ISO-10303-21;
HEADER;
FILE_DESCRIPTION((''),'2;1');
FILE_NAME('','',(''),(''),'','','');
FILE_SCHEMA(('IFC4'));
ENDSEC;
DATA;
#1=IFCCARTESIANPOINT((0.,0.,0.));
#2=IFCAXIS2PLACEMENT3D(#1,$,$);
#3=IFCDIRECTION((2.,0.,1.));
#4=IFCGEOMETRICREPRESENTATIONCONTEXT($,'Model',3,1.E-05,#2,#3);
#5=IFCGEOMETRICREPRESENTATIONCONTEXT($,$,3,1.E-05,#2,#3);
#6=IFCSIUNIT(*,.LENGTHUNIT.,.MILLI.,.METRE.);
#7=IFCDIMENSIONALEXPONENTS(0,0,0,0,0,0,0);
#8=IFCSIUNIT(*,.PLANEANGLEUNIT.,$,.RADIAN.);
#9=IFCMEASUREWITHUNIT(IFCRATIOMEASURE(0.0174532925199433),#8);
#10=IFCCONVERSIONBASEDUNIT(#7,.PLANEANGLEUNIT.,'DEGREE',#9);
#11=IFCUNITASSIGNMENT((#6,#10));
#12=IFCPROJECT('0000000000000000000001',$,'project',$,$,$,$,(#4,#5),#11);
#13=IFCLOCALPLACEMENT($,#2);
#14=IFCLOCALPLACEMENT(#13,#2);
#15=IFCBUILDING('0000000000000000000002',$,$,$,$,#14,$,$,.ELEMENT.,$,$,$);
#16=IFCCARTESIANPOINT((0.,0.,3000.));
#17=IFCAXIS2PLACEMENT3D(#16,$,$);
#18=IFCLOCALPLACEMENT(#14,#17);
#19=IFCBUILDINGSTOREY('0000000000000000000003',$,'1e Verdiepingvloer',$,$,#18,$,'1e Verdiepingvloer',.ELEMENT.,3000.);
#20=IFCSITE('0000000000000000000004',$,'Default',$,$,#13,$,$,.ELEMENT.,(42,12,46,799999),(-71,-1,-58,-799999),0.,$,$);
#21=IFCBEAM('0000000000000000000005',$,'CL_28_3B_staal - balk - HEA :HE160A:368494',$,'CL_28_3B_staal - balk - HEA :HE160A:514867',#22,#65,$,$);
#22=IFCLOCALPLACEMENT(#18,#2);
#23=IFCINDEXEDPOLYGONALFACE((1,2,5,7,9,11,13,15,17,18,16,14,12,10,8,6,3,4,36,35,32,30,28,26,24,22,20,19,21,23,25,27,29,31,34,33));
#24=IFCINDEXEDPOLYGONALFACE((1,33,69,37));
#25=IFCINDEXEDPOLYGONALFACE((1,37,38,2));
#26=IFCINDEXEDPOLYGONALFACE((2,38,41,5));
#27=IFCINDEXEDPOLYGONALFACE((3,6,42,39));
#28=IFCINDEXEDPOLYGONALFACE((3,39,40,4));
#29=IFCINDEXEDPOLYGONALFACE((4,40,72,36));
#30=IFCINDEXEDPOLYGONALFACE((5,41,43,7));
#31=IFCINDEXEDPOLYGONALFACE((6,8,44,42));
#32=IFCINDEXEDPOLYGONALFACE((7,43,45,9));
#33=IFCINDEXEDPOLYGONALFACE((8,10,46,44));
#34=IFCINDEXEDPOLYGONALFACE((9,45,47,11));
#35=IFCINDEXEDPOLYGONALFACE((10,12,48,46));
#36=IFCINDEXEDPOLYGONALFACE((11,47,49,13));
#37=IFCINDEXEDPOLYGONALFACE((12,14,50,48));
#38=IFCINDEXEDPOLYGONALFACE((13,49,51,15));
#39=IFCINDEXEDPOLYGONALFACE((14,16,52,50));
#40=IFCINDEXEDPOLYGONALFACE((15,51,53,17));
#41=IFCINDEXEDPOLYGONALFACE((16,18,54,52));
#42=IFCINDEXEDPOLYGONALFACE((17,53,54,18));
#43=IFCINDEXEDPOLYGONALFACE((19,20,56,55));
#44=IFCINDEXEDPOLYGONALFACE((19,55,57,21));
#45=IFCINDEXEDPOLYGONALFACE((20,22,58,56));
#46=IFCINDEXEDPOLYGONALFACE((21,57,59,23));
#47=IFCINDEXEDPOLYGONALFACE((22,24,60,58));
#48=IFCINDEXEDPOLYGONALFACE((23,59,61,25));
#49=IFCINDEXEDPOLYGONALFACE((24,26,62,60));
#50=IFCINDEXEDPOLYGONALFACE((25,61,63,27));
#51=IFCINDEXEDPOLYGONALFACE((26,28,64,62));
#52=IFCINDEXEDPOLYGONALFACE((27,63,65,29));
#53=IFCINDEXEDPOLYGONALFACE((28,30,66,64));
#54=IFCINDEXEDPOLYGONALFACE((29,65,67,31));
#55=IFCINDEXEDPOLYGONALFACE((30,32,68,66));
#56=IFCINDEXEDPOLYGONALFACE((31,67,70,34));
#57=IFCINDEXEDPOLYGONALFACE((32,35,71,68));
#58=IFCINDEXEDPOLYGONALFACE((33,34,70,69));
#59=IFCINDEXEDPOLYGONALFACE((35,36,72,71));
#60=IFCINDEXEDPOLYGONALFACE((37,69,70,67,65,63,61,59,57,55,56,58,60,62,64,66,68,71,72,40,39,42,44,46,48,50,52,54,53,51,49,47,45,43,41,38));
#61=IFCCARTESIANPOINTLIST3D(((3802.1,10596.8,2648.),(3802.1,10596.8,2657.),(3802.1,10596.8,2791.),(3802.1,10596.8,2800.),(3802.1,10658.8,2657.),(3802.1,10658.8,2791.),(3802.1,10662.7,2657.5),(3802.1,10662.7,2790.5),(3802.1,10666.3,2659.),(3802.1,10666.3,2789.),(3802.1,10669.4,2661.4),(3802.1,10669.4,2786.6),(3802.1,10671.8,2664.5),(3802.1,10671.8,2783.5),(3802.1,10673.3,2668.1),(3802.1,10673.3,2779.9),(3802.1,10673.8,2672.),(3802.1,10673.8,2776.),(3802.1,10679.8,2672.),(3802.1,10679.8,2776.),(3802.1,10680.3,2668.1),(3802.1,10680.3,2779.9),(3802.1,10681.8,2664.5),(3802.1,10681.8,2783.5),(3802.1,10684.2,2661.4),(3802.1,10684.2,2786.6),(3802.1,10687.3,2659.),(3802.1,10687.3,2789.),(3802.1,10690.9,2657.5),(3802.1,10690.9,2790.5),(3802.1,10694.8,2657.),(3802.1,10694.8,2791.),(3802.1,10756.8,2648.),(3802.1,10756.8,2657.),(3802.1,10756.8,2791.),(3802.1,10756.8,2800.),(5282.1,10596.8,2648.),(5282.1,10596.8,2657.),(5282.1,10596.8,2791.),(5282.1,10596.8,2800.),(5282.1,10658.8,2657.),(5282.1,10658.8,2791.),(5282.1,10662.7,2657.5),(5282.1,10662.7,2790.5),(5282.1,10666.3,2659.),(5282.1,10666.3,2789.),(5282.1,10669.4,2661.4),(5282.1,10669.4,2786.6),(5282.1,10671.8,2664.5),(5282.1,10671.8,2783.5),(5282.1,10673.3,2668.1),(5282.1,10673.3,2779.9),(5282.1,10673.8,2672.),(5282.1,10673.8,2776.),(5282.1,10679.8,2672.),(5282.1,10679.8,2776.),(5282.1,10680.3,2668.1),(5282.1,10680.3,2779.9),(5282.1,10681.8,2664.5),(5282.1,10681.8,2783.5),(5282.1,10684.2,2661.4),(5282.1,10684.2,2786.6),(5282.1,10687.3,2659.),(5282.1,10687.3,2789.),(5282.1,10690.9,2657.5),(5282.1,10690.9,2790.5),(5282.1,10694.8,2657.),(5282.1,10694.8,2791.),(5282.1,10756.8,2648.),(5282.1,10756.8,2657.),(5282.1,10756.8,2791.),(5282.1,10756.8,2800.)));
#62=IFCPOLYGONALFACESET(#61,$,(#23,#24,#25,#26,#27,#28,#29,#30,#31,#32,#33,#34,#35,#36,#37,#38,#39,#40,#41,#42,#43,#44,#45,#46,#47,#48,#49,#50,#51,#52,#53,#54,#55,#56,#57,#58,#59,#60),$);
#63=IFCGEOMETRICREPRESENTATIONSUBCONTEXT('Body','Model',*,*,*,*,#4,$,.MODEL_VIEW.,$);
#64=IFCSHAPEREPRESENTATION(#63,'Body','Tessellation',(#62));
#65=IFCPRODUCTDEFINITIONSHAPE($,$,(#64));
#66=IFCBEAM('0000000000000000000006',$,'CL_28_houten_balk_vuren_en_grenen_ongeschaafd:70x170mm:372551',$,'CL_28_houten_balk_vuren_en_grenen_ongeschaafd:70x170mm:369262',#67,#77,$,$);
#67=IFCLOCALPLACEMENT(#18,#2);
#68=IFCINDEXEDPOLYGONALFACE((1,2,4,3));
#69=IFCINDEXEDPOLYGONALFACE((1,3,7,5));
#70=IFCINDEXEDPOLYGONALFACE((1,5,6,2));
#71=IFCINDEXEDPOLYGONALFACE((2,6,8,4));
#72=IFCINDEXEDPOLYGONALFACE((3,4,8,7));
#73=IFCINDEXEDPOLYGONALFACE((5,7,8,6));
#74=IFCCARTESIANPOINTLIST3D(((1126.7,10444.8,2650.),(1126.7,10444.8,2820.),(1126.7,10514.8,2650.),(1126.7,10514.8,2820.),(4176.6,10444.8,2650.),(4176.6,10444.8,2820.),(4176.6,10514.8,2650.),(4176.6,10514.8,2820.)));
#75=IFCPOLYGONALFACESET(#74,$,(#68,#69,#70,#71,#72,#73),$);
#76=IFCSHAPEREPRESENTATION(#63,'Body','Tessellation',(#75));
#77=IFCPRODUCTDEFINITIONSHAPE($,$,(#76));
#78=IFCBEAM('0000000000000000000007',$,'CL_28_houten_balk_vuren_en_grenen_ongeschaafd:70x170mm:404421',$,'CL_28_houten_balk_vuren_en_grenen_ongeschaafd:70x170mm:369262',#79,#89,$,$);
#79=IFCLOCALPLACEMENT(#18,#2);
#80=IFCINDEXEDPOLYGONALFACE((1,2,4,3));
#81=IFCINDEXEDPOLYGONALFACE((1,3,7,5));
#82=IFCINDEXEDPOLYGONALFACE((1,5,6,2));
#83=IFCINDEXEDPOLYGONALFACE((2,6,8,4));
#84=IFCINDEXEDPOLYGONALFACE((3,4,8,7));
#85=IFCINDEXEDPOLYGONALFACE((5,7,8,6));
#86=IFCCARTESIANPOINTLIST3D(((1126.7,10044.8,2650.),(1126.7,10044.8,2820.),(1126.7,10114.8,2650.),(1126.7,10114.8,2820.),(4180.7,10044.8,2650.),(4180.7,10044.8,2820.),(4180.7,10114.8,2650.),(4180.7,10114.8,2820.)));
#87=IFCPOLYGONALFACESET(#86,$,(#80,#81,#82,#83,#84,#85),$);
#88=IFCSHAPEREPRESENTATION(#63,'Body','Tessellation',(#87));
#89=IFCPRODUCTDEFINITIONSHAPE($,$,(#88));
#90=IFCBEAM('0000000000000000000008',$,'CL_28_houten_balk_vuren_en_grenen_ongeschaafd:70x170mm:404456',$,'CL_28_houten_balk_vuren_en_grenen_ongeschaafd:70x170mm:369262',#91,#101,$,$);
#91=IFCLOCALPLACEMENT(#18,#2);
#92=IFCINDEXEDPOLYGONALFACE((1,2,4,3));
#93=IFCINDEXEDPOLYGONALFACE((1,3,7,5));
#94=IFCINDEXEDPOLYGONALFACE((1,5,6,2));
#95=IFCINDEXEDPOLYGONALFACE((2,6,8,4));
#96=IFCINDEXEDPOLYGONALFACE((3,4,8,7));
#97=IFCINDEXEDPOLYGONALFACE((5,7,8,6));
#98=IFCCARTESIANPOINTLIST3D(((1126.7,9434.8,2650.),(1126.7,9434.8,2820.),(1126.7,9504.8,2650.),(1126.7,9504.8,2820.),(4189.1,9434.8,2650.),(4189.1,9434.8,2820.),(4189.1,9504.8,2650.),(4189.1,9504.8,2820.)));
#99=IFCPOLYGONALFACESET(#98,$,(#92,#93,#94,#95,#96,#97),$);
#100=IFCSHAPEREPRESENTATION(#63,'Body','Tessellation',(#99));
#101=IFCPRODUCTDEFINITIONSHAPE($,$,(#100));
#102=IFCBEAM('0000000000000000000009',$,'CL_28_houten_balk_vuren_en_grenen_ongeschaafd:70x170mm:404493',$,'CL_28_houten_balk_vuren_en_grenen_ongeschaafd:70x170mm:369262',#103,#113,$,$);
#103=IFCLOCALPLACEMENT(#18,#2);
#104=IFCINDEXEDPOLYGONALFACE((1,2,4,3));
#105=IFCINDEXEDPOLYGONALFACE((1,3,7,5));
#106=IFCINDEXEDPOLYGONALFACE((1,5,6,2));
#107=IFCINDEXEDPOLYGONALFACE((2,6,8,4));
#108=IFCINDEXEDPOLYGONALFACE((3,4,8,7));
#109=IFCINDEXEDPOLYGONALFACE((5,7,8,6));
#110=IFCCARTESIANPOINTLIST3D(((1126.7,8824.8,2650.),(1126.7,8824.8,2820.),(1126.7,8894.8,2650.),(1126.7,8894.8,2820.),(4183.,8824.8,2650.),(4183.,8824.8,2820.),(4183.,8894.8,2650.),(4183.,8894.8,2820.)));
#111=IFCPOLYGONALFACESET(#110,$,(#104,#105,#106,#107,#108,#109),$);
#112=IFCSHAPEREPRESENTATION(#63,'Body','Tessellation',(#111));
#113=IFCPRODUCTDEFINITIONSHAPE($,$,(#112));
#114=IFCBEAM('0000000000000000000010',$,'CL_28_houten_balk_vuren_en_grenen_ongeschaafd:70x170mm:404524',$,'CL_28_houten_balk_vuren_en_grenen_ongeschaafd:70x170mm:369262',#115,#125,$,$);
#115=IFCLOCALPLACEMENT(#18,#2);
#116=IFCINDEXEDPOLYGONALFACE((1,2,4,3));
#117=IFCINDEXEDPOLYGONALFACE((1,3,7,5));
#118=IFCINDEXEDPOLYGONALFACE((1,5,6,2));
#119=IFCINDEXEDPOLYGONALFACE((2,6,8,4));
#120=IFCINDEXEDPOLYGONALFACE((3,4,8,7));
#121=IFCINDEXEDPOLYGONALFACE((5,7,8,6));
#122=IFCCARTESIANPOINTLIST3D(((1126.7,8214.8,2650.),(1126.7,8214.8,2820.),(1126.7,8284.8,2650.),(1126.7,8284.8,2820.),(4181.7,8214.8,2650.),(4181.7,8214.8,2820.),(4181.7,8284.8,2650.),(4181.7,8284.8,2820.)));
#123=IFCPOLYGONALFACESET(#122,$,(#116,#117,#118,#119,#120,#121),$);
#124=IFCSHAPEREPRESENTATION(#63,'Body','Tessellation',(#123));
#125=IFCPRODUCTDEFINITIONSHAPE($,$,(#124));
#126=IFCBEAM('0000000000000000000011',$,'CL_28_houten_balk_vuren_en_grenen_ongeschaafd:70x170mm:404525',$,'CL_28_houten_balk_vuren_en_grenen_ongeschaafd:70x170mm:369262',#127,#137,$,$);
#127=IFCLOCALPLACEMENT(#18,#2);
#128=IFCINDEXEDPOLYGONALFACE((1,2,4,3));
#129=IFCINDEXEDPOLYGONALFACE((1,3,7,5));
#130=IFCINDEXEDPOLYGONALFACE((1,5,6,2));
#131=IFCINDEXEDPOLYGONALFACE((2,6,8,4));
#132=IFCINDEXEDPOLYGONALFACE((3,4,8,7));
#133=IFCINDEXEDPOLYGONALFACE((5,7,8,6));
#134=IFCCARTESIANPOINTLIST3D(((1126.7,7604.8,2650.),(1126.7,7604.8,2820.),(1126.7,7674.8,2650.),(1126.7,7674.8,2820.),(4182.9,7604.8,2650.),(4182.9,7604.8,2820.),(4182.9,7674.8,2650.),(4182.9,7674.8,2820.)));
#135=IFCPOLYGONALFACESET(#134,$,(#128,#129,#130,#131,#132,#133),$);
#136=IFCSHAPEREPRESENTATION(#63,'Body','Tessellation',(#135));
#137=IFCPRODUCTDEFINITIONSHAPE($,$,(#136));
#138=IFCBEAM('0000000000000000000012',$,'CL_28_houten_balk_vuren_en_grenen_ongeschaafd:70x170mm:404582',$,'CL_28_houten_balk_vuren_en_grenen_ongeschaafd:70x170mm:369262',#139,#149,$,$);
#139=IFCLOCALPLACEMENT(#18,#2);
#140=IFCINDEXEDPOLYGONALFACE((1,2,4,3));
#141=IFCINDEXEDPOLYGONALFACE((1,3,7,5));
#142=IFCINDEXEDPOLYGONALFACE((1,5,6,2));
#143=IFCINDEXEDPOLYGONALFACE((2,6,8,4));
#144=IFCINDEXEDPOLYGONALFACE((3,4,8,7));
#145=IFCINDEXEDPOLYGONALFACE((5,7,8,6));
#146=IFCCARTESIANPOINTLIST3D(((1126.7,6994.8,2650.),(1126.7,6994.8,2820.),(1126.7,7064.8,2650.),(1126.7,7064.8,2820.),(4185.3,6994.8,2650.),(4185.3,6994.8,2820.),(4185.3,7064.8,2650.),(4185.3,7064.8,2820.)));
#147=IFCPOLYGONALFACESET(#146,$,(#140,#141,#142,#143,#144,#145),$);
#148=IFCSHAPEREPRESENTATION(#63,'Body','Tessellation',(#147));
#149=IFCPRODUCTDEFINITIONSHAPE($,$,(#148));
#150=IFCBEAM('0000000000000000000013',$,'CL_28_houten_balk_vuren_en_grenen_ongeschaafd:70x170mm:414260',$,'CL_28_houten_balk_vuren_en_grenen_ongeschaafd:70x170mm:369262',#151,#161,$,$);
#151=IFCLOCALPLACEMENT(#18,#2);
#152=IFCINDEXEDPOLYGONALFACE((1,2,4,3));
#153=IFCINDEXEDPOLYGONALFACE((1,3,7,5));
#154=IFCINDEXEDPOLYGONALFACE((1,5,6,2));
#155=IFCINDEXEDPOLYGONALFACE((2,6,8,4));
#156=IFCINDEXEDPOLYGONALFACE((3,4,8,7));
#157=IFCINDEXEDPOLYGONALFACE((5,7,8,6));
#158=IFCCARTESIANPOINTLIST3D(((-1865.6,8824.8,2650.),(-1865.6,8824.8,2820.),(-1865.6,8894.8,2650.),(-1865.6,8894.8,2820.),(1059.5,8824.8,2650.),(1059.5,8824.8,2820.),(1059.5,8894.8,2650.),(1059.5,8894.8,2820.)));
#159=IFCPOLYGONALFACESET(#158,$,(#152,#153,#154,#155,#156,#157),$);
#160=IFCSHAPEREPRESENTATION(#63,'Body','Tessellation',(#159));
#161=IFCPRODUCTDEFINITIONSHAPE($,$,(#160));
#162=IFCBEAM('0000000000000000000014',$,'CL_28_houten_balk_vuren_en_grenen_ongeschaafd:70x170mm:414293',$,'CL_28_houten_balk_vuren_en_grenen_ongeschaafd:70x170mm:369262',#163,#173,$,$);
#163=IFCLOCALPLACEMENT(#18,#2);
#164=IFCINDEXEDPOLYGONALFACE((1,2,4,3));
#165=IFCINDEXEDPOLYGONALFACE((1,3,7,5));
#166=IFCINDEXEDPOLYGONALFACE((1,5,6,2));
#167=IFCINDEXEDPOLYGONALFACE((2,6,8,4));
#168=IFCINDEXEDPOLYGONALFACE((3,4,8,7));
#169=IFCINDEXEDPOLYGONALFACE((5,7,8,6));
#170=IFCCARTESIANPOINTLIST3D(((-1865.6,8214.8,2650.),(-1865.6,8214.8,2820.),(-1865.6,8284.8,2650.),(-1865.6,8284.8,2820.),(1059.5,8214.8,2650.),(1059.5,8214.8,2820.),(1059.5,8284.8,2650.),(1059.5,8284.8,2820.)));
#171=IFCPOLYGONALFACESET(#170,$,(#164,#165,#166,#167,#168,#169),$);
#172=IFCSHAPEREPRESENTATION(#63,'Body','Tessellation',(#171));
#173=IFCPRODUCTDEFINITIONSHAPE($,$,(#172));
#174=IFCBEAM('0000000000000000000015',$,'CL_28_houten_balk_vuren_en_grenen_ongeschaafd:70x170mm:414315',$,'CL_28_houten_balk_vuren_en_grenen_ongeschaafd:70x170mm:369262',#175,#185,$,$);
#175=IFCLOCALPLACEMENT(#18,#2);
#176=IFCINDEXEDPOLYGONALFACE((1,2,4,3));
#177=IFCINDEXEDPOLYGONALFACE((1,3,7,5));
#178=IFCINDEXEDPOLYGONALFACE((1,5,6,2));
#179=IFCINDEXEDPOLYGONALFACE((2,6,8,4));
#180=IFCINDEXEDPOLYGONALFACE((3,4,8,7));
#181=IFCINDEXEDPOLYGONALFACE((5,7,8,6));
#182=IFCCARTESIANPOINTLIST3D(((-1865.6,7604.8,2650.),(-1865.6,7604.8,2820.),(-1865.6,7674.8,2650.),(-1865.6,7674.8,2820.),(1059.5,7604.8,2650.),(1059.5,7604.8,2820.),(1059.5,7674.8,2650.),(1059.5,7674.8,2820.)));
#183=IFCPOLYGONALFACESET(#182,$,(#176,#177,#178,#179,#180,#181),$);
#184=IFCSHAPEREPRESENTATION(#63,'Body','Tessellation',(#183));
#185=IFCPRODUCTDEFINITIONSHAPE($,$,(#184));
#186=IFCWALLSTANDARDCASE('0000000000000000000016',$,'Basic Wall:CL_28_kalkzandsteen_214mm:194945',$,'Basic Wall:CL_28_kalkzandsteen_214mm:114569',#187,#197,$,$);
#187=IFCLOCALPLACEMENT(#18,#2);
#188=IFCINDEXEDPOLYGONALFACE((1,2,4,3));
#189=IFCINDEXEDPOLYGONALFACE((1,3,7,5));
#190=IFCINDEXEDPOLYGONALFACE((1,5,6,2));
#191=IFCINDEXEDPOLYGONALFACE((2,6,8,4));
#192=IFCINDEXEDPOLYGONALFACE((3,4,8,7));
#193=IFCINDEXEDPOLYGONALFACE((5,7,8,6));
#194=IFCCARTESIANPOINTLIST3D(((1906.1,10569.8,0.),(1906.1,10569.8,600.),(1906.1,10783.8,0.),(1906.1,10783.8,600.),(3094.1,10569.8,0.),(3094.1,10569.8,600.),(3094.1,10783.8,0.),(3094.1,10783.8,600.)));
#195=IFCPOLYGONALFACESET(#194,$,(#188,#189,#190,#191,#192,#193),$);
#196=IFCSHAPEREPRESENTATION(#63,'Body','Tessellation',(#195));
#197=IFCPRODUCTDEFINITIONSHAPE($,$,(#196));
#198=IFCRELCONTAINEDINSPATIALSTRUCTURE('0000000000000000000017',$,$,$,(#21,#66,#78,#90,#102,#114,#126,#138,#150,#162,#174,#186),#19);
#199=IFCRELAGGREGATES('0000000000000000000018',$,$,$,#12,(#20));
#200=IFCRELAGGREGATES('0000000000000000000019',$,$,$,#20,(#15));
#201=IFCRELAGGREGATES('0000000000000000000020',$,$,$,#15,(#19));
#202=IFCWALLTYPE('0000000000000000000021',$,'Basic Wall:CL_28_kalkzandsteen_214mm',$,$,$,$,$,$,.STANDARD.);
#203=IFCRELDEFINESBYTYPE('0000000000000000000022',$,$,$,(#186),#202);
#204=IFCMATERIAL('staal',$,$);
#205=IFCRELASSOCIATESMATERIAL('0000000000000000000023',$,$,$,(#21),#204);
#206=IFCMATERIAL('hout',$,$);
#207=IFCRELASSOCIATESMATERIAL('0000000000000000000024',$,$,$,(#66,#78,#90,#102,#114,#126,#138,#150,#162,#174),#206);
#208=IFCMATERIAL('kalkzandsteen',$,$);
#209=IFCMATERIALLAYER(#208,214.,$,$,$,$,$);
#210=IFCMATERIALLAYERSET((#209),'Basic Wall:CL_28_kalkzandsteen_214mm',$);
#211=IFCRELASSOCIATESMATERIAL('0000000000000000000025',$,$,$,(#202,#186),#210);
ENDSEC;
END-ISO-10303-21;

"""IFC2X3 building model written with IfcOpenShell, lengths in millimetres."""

from ifc_helpers import new_model, entity, si_unit, converted_unit, direction, frame, frame_2d, origin, place, context, subcontext, project, spatial, rectangle, i_section, extrude, material, layer, layer_set, layer_usage, type_object, element, save


model = new_model("IFC2X3")

# Units and contexts
model_context = context("Model", 3, precision=1e-05, world=origin(), true_north=direction((2.0, 0.0, 1.0)))
context_of_model = context(None, 3, precision=1e-05, world=origin(), true_north=direction((2.0, 0.0, 1.0)))
body_context = subcontext(model_context, "Body", "Model", "MODEL_VIEW")
ifc_project = project(units=[si_unit("LENGTHUNIT", "METRE", prefix="MILLI"), converted_unit("PLANEANGLEUNIT", "DEGREE", entity("IfcRatioMeasure", 0.0174532925199433), si_unit("PLANEANGLEUNIT", "RADIAN"), dimensions=[0, 0, 0, 0, 0, 0, 0])], contexts=[model_context, context_of_model])

# Site, building, storey
site_placement = place(None, origin())
site = spatial("IfcSite", under=ifc_project, at=site_placement, Name="Default", CompositionType="ELEMENT", RefLatitude=(42, 12, 46, 799999), RefLongitude=(-71, -1, -58, -799999), RefElevation=0.0)
building_placement = place(site_placement, origin())
building = spatial("IfcBuilding", under=site, at=building_placement, CompositionType="ELEMENT")
storey_placement = place(building_placement, frame((0.0, 0.0, 3000.0)))
storey = spatial("IfcBuildingStorey", under=building, at=storey_placement, Name="1e Verdiepingvloer", LongName="1e Verdiepingvloer", CompositionType="ELEMENT", Elevation=3000.0)

# Beams
ifc_material_1 = material(Name="staal")
beam_1_placement = place(storey_placement, frame((3802.1, 10676.8, 2800.0)))
element("IfcBeam", 1, at=beam_1_placement, inside=storey, material=ifc_material_1, Name="CL_28_3B_staal - balk - HEA :HE160A:368494", ObjectType="CL_28_3B_staal - balk - HEA :HE160A:514867", context=body_context, shape_type="SweptSolid", body=[
    extrude(i_section(OverallWidth=160.0, OverallDepth=152.0, WebThickness=6.0, FlangeThickness=9.0, FilletRadius=15.0, at=frame_2d((0.0, 0.0), x_axis=(0.0, 1.0))), frame((0.0, 0.0, -76.0), z_axis=(1.0, 0.0, 0.0), x_axis=(0.0, 0.0, -1.0)), (0.0, 0.0, 1.0), 1480.0),
])
ifc_material_2 = material(Name="hout")
beam_2_placement = place(storey_placement, frame((971.1, 10479.8, 2820.0)))
element("IfcBeam", 2, at=beam_2_placement, inside=storey, material=ifc_material_2, Name="CL_28_houten_balk_vuren_en_grenen_ongeschaafd:70x170mm:372551", ObjectType="CL_28_houten_balk_vuren_en_grenen_ongeschaafd:70x170mm:369262", context=body_context, shape_type="SweptSolid", body=[
    extrude(rectangle(XDim=170.0, YDim=70.0, at=frame_2d((0.0, 0.0), x_axis=(1.0, 0.0))), frame((155.6, 0.0, -85.0), z_axis=(1.0, 0.0, 0.0), x_axis=(0.0, 0.0, -1.0)), (0.0, 0.0, 1.0), 3049.9),
])
beam_3_placement = place(storey_placement, frame((971.1, 10079.8, 2820.0)))
element("IfcBeam", 3, at=beam_3_placement, inside=storey, material=ifc_material_2, Name="CL_28_houten_balk_vuren_en_grenen_ongeschaafd:70x170mm:404421", ObjectType="CL_28_houten_balk_vuren_en_grenen_ongeschaafd:70x170mm:369262", context=body_context, shape_type="SweptSolid", body=[
    extrude(rectangle(XDim=170.0, YDim=70.0, at=frame_2d((0.0, 0.0), x_axis=(1.0, 0.0))), frame((155.6, 0.0, -85.0), z_axis=(1.0, 0.0, 0.0), x_axis=(0.0, 0.0, -1.0)), (0.0, 0.0, 1.0), 3054.1),
])
beam_4_placement = place(storey_placement, frame((971.1, 9469.8, 2820.0)))
element("IfcBeam", 4, at=beam_4_placement, inside=storey, material=ifc_material_2, Name="CL_28_houten_balk_vuren_en_grenen_ongeschaafd:70x170mm:404456", ObjectType="CL_28_houten_balk_vuren_en_grenen_ongeschaafd:70x170mm:369262", context=body_context, shape_type="SweptSolid", body=[
    extrude(rectangle(XDim=170.0, YDim=70.0, at=frame_2d((0.0, 0.0), x_axis=(1.0, 0.0))), frame((155.6, 0.0, -85.0), z_axis=(1.0, 0.0, 0.0), x_axis=(0.0, 0.0, -1.0)), (0.0, 0.0, 1.0), 3062.4),
])
beam_5_placement = place(storey_placement, frame((971.1, 8859.8, 2820.0)))
element("IfcBeam", 5, at=beam_5_placement, inside=storey, material=ifc_material_2, Name="CL_28_houten_balk_vuren_en_grenen_ongeschaafd:70x170mm:404493", ObjectType="CL_28_houten_balk_vuren_en_grenen_ongeschaafd:70x170mm:369262", context=body_context, shape_type="SweptSolid", body=[
    extrude(rectangle(XDim=170.0, YDim=70.0, at=frame_2d((0.0, 0.0), x_axis=(1.0, 0.0))), frame((155.6, 0.0, -85.0), z_axis=(1.0, 0.0, 0.0), x_axis=(0.0, 0.0, -1.0)), (0.0, 0.0, 1.0), 3056.3),
])
beam_6_placement = place(storey_placement, frame((971.1, 8249.8, 2820.0)))
element("IfcBeam", 6, at=beam_6_placement, inside=storey, material=ifc_material_2, Name="CL_28_houten_balk_vuren_en_grenen_ongeschaafd:70x170mm:404524", ObjectType="CL_28_houten_balk_vuren_en_grenen_ongeschaafd:70x170mm:369262", context=body_context, shape_type="SweptSolid", body=[
    extrude(rectangle(XDim=170.0, YDim=70.0, at=frame_2d((0.0, 0.0), x_axis=(1.0, 0.0))), frame((155.6, 0.0, -85.0), z_axis=(1.0, 0.0, 0.0), x_axis=(0.0, 0.0, -1.0)), (0.0, 0.0, 1.0), 3055.0),
])
beam_7_placement = place(storey_placement, frame((971.1, 7639.8, 2820.0)))
element("IfcBeam", 7, at=beam_7_placement, inside=storey, material=ifc_material_2, Name="CL_28_houten_balk_vuren_en_grenen_ongeschaafd:70x170mm:404525", ObjectType="CL_28_houten_balk_vuren_en_grenen_ongeschaafd:70x170mm:369262", context=body_context, shape_type="SweptSolid", body=[
    extrude(rectangle(XDim=170.0, YDim=70.0, at=frame_2d((0.0, 0.0), x_axis=(1.0, 0.0))), frame((155.6, 0.0, -85.0), z_axis=(1.0, 0.0, 0.0), x_axis=(0.0, 0.0, -1.0)), (0.0, 0.0, 1.0), 3056.2),
])
beam_8_placement = place(storey_placement, frame((971.1, 7029.8, 2820.0)))
element("IfcBeam", 8, at=beam_8_placement, inside=storey, material=ifc_material_2, Name="CL_28_houten_balk_vuren_en_grenen_ongeschaafd:70x170mm:404582", ObjectType="CL_28_houten_balk_vuren_en_grenen_ongeschaafd:70x170mm:369262", context=body_context, shape_type="SweptSolid", body=[
    extrude(rectangle(XDim=170.0, YDim=70.0, at=frame_2d((0.0, 0.0), x_axis=(1.0, 0.0))), frame((155.6, 0.0, -85.0), z_axis=(1.0, 0.0, 0.0), x_axis=(0.0, 0.0, -1.0)), (0.0, 0.0, 1.0), 3058.6),
])
for number, where, name in (
    (9, (-2128.9, 8859.8, 2820.0), "CL_28_houten_balk_vuren_en_grenen_ongeschaafd:70x170mm:414260"),
    (10, (-2128.9, 8249.8, 2820.0), "CL_28_houten_balk_vuren_en_grenen_ongeschaafd:70x170mm:414293"),
    (11, (-2128.9, 7639.8, 2820.0), "CL_28_houten_balk_vuren_en_grenen_ongeschaafd:70x170mm:414315"),
):
    element("IfcBeam", number, at=place(storey_placement, frame(where)), inside=storey, material=ifc_material_2, Name=name, ObjectType="CL_28_houten_balk_vuren_en_grenen_ongeschaafd:70x170mm:369262", context=body_context, shape_type="SweptSolid", body=[
        extrude(rectangle(XDim=170.0, YDim=70.0, at=frame_2d((0.0, 0.0), x_axis=(1.0, 0.0))), frame((263.4, 0.0, -85.0), z_axis=(1.0, 0.0, 0.0), x_axis=(0.0, 0.0, -1.0)), (0.0, 0.0, 1.0), 2925.0),
    ])

# Wall
ifc_material_3 = material(Name="kalkzandsteen")
ifc_layer = layer(ifc_material_3, 214.0)
ifc_layer_set = layer_set([ifc_layer], Name="Basic Wall:CL_28_kalkzandsteen_214mm")
ifc_layer_usage_1 = layer_usage(ifc_layer_set, "AXIS2", "NEGATIVE", 107.0)
wall_type = type_object("IfcWallType", Name="Basic Wall:CL_28_kalkzandsteen_214mm", PredefinedType="STANDARD", material=ifc_layer_set)
wall_1_placement = place(storey_placement, frame((3094.1, 10676.8, 0.0), z_axis=(0.0, 0.0, 1.0), x_axis=(-1.0, 0.0, 0.0)))
element("IfcWallStandardCase", 12, at=wall_1_placement, inside=storey, type_object=wall_type, material=ifc_layer_usage_1, Name="Basic Wall:CL_28_kalkzandsteen_214mm:194945", ObjectType="Basic Wall:CL_28_kalkzandsteen_214mm:114569", context=body_context, shape_type="SweptSolid", body=[
    extrude(rectangle(XDim=1188.0, YDim=214.0, at=frame_2d((594.0, 0.0), x_axis=(-1.0, 0.0))), origin(), (0.0, 0.0, 1.0), 600.0),
])

save(model, "model.ifc")
